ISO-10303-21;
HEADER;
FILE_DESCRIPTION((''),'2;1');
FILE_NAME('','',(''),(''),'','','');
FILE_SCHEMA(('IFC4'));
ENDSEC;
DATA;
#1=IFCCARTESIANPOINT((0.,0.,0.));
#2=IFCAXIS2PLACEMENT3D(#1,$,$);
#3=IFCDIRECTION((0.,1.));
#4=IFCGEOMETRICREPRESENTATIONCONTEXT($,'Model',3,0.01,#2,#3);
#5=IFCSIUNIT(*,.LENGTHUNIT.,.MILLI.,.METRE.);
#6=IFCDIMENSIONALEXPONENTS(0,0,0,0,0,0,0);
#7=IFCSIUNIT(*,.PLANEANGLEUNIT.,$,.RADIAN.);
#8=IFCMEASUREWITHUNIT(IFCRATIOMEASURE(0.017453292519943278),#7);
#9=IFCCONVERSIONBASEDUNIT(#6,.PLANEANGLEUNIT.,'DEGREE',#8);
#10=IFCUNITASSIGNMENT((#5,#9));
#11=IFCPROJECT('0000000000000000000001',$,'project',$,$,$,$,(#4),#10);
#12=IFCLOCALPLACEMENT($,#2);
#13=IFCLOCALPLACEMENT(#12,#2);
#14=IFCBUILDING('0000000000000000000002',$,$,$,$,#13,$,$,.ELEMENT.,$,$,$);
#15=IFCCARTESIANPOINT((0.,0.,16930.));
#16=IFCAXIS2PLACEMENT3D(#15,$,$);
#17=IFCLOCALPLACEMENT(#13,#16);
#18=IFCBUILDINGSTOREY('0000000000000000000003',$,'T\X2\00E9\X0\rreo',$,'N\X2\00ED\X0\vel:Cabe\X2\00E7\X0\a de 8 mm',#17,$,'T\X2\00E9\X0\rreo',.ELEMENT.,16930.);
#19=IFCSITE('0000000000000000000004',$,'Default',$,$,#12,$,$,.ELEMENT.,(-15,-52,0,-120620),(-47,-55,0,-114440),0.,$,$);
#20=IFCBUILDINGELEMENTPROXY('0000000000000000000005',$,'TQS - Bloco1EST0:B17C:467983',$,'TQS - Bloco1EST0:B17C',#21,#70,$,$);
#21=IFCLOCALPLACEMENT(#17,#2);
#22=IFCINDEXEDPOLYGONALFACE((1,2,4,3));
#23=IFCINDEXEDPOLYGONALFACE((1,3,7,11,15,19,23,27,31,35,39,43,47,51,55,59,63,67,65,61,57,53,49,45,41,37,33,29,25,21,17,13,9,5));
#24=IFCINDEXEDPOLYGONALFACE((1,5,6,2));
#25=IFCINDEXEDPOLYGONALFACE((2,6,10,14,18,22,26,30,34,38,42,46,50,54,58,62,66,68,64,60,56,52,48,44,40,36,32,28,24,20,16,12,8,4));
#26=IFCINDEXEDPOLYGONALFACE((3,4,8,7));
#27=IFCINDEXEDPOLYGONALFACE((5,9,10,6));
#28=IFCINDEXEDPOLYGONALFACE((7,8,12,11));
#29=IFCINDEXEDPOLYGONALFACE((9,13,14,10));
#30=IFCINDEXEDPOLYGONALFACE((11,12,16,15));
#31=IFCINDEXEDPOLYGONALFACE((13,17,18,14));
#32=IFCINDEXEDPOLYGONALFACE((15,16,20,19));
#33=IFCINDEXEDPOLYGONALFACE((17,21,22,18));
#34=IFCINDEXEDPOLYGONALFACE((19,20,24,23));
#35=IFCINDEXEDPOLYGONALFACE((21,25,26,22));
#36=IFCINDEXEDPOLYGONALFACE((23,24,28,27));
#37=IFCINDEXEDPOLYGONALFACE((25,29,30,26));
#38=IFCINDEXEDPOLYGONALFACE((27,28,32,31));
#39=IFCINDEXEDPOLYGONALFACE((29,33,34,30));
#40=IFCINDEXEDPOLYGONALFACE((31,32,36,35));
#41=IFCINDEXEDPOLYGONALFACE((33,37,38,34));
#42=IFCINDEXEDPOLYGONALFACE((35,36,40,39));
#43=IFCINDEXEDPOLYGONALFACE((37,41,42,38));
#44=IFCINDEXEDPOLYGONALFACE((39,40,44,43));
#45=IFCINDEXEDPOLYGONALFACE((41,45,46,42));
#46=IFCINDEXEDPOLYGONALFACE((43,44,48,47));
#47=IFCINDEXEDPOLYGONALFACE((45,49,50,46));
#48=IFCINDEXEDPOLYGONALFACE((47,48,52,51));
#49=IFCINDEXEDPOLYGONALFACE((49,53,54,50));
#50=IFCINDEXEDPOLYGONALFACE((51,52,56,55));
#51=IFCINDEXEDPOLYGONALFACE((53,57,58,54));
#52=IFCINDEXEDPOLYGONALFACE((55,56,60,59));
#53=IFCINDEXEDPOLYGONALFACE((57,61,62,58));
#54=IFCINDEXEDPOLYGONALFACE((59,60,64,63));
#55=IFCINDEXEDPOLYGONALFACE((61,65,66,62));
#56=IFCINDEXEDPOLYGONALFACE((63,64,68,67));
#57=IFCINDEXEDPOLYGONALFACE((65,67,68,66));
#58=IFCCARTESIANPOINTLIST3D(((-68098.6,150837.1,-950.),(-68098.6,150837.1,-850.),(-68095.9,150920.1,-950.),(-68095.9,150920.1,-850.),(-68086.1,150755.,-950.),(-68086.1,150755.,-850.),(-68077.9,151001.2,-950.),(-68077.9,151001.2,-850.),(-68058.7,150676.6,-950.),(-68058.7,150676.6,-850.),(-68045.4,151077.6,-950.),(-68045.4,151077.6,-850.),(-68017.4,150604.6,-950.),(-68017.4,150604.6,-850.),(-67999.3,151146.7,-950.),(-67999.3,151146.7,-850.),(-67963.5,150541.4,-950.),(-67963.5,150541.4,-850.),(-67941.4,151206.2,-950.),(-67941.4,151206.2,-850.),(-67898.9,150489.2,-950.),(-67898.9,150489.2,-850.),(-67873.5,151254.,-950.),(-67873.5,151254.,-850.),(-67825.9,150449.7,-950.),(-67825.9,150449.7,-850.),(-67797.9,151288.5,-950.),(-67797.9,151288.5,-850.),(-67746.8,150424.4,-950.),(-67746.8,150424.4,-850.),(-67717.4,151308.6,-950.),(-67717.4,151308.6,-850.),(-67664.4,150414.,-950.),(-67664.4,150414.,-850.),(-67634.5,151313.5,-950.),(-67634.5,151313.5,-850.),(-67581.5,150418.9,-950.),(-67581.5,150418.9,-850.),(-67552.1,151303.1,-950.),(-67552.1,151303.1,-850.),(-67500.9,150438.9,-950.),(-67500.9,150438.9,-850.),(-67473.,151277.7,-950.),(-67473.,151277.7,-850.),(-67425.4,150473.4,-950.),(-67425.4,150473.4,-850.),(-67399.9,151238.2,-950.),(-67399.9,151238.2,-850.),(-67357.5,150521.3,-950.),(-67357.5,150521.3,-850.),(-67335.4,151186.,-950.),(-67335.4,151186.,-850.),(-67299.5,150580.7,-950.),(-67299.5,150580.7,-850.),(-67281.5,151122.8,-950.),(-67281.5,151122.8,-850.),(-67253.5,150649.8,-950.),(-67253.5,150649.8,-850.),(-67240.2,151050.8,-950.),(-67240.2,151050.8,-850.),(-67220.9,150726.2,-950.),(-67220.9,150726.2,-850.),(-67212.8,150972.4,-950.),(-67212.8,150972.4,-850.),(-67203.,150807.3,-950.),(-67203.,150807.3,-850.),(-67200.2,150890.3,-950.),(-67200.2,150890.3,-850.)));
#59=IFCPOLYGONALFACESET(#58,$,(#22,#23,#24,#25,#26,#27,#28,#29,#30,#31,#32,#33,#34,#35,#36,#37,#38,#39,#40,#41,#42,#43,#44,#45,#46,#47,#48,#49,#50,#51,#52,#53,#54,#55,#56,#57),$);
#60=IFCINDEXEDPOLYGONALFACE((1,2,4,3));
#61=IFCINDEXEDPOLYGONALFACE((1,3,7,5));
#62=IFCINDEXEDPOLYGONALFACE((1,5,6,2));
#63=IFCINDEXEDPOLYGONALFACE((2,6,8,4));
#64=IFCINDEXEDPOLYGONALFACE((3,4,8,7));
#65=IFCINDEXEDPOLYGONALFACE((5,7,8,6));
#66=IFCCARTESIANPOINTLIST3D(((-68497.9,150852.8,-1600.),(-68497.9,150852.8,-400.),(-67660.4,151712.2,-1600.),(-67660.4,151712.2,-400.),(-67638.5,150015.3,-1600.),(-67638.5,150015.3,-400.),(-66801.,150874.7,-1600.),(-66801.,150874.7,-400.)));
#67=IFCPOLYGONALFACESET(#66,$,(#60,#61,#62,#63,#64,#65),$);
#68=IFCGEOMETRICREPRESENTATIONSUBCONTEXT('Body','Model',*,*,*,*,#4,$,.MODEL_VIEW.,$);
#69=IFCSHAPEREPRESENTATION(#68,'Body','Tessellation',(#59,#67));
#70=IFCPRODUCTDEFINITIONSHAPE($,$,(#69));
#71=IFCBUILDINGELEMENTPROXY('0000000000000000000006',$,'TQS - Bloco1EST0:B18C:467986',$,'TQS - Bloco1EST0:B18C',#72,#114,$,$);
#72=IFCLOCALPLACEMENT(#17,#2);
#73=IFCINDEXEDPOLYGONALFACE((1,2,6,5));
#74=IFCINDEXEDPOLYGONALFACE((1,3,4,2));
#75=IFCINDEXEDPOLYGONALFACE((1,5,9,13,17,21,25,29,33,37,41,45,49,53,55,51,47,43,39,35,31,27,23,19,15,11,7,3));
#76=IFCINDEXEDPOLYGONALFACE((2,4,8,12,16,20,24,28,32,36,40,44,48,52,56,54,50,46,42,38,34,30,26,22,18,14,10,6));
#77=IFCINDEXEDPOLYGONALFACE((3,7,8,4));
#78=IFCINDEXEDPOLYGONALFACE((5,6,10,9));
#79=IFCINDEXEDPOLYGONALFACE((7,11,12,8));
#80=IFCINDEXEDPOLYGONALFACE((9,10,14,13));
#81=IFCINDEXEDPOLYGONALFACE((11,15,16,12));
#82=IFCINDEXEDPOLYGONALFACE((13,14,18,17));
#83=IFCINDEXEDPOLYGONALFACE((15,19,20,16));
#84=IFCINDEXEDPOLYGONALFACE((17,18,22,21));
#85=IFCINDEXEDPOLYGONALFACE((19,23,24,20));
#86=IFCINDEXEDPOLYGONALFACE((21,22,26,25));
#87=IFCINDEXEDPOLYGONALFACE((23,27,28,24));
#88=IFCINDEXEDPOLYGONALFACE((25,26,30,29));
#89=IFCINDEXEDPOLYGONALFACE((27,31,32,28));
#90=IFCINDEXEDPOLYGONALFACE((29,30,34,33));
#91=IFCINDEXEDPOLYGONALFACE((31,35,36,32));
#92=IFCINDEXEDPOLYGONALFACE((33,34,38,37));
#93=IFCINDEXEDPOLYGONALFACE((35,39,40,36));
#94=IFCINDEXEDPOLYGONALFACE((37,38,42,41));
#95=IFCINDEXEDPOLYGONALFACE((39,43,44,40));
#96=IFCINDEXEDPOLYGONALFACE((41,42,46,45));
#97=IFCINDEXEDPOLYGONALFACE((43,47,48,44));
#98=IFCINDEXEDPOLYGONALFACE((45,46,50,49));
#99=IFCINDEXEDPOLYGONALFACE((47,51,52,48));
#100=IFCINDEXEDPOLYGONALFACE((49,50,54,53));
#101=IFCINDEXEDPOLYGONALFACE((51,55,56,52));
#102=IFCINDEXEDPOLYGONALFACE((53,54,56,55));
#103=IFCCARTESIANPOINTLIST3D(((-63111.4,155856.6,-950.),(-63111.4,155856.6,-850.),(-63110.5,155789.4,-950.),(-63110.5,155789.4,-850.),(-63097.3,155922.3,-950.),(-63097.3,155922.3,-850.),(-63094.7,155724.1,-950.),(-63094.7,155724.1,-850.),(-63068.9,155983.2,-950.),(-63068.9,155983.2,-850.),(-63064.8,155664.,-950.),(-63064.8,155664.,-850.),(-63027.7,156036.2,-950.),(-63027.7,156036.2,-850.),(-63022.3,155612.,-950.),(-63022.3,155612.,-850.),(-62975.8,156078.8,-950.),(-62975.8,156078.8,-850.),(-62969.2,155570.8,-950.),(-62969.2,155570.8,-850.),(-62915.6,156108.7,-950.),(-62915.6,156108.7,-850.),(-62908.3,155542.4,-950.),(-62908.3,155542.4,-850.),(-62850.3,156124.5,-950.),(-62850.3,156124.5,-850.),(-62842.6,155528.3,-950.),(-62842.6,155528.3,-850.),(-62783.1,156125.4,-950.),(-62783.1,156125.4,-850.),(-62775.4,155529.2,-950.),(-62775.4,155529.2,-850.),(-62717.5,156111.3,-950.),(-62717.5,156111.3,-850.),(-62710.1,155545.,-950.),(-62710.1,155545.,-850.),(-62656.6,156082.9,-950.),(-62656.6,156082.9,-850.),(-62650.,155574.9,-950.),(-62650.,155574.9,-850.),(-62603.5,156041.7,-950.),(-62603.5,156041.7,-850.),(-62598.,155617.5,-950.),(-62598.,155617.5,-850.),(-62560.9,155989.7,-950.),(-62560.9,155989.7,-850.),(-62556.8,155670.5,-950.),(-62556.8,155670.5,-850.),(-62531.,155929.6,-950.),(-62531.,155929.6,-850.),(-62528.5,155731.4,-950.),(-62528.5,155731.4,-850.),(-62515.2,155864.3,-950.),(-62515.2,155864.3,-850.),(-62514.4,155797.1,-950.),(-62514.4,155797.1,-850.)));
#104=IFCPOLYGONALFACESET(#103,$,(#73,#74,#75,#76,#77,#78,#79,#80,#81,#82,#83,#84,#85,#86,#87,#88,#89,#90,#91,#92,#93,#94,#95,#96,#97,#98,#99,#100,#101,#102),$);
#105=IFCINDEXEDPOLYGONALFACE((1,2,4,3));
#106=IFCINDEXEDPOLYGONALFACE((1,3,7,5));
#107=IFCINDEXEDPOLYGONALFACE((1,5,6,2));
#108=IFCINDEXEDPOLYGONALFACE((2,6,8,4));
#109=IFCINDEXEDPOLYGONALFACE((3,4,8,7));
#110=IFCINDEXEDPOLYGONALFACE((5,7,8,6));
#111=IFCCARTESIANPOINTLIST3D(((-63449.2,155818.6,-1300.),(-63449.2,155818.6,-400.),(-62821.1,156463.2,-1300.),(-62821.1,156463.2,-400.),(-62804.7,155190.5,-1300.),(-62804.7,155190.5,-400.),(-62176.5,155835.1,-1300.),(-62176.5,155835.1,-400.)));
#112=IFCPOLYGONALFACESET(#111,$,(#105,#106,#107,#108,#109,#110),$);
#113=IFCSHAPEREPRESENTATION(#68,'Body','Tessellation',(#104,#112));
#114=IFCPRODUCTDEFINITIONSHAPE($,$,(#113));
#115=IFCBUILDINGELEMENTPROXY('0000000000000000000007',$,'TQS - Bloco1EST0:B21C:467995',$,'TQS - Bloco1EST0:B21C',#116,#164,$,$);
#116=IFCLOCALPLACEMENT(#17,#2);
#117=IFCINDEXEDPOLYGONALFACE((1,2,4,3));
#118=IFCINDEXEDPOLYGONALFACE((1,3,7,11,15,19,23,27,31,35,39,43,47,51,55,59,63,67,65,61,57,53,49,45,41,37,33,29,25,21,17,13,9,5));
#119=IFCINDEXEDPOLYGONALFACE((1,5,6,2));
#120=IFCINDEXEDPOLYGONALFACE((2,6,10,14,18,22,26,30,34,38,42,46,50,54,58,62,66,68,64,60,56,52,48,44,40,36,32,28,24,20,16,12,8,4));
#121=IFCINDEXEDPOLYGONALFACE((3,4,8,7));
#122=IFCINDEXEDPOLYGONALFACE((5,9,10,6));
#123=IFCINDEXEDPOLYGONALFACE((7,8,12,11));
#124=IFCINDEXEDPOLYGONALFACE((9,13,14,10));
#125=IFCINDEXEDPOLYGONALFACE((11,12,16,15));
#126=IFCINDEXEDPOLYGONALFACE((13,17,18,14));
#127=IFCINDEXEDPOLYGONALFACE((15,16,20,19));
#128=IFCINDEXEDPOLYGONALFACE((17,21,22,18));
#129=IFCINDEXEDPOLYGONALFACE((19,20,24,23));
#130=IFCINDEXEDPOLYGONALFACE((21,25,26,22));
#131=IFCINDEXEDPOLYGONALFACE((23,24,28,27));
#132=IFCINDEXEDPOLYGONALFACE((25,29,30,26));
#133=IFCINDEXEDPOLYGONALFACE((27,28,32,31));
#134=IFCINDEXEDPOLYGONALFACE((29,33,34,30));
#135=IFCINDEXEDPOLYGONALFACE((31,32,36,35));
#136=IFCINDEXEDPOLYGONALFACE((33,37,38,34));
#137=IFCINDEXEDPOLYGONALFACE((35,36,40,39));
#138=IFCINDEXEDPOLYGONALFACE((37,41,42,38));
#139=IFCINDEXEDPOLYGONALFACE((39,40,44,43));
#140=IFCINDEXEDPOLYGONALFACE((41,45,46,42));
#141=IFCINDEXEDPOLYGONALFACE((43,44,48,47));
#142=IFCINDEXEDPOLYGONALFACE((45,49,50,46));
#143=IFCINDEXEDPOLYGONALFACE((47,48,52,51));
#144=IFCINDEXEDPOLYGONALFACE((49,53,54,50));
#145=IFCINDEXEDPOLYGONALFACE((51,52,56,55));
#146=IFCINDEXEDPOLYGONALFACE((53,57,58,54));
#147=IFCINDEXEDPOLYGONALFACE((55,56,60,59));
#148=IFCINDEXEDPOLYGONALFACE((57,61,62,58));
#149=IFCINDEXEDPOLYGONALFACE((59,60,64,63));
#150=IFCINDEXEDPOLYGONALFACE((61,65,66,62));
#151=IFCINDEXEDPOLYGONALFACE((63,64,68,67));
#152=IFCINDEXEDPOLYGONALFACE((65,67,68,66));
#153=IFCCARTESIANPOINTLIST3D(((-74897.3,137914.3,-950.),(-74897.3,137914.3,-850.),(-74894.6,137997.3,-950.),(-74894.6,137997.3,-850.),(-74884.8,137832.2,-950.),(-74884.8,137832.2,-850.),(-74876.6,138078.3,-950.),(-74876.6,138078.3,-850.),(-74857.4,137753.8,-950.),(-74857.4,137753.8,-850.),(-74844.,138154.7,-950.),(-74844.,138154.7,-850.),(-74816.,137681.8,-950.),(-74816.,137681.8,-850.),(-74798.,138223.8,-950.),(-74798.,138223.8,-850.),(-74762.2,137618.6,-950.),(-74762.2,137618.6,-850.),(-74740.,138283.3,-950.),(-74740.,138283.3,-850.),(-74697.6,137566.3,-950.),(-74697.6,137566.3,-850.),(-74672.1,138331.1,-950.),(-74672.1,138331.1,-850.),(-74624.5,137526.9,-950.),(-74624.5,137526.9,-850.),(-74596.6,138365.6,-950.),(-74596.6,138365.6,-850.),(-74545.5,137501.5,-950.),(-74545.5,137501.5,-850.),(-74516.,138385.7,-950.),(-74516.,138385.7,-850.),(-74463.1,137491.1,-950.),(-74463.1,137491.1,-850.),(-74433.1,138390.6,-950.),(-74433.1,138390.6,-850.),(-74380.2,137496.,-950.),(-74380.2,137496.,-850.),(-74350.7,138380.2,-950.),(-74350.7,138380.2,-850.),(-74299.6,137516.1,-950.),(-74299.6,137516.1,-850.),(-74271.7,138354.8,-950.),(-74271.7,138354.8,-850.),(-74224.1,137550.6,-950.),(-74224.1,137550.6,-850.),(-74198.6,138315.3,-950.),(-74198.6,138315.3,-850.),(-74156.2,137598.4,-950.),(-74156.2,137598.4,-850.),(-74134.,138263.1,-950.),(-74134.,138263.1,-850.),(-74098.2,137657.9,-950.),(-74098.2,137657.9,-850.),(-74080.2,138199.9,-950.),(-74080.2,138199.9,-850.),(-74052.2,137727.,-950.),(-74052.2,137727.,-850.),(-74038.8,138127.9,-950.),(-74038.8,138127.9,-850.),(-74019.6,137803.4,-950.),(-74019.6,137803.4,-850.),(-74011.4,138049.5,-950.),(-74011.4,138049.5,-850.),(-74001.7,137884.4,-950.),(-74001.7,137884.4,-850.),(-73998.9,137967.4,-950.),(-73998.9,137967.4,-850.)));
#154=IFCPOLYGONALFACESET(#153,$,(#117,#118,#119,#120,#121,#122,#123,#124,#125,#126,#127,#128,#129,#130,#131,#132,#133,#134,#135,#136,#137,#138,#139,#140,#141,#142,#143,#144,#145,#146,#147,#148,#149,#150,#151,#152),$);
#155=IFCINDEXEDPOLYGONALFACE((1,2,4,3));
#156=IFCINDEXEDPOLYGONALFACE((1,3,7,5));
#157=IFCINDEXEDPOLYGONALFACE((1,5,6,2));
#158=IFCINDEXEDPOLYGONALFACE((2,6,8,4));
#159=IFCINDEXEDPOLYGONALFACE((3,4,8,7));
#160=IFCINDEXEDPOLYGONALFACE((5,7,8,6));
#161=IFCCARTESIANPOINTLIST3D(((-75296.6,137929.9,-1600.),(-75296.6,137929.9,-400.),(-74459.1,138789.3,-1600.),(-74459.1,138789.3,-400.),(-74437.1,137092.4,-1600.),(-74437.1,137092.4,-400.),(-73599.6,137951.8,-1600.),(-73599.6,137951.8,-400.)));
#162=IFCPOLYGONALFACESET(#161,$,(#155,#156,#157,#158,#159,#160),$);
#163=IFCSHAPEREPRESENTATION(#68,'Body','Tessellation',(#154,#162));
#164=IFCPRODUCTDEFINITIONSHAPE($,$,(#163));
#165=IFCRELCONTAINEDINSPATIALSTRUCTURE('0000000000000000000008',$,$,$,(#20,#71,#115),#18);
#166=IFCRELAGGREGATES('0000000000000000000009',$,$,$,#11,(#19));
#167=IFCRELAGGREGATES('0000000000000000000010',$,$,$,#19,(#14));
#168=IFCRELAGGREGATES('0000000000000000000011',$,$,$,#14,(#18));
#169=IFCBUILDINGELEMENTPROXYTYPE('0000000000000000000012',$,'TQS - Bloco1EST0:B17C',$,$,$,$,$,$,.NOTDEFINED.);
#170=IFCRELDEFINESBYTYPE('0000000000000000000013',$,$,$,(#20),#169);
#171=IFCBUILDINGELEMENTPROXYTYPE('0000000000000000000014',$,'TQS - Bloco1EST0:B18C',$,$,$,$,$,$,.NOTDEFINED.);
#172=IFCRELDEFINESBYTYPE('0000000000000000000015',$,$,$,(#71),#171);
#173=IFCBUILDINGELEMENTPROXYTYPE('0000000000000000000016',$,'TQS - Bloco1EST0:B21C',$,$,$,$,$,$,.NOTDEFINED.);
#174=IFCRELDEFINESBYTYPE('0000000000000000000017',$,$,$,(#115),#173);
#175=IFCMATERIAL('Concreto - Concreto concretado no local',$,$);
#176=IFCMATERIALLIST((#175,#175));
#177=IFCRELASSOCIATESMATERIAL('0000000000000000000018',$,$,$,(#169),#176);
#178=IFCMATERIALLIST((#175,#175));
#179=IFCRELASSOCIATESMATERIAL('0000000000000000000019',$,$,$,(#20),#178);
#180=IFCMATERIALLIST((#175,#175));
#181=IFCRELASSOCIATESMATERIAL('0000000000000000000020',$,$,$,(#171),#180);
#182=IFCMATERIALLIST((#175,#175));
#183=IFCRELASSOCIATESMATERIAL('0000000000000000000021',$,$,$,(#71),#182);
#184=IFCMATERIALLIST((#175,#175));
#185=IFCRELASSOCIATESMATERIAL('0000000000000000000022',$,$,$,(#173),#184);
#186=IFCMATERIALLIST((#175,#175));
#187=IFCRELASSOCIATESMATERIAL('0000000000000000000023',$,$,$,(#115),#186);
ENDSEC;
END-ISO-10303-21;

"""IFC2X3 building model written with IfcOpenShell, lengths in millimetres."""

from ifc_helpers import new_model, entity, si_unit, converted_unit, direction, frame, frame_2d, origin, origin_2d_with_axis, place, context, subcontext, project, spatial, rectangle, circle, extrude, source, transform, mapped, material, material_list, type_object, type_shapes, element, save


model = new_model("IFC2X3")

# Units and contexts
model_context = context("Model", 3, precision=0.01, world=origin(), true_north=direction((0.0, 1.0)))
body_context = subcontext(model_context, "Body", "Model", "MODEL_VIEW")
ifc_project = project(units=[si_unit("LENGTHUNIT", "METRE", prefix="MILLI"), converted_unit("PLANEANGLEUNIT", "DEGREE", entity("IfcRatioMeasure", 0.017453292519943278), si_unit("PLANEANGLEUNIT", "RADIAN"), dimensions=[0, 0, 0, 0, 0, 0, 0])], contexts=[model_context])

# Site, building, storey
site_placement = place(None, origin())
site = spatial("IfcSite", under=ifc_project, at=site_placement, Name="Default", CompositionType="ELEMENT", RefLatitude=(-15, -52, 0, -120620), RefLongitude=(-47, -55, 0, -114440), RefElevation=0.0)
building_placement = place(site_placement, origin())
building = spatial("IfcBuilding", under=site, at=building_placement, CompositionType="ELEMENT")
storey_placement = place(building_placement, frame((0.0, 0.0, 16930.0)))
storey = spatial("IfcBuildingStorey", under=building, at=storey_placement, Name="Térreo", ObjectType="Nível:Cabeça de 8 mm", LongName="Térreo", CompositionType="ELEMENT", Elevation=16930.0)

# Building element proxies
ifc_material_1 = material(Name="Concreto - Concreto concretado no local")
ifc_material_list_1 = material_list([ifc_material_1, ifc_material_1])
ifc_material_list_2 = material_list([ifc_material_1, ifc_material_1])
building_element_proxy_type_1 = type_object("IfcBuildingElementProxyType", Name="TQS - Bloco1EST0:B17C", PredefinedType="NOTDEFINED", material=ifc_material_list_2)
shared_shape_1 = source(origin(), body_context, "Body", "SweptSolid", [
    extrude(circle(Radius=450.0, at=frame_2d((0.0, 0.0), x_axis=(1.0, 0.0))), frame((0.0, 0.0, -550.0)), (0.0, 0.0, 1.0), 100.0),
    extrude(rectangle(XDim=1200.0, YDim=1200.0, at=origin_2d_with_axis()), frame((0.0, 0.0, -1200.0), z_axis=(0.0, 0.0, 1.0), x_axis=(-1.0, 0.0, 0.0)), (0.0, 0.0, 1.0), 1200.0),
])
type_shapes(building_element_proxy_type_1, [shared_shape_1])
proxy_1_placement = place(storey_placement, frame((-67649.4, 150863.7, -400.0), z_axis=(0.0, 0.0, 1.0), x_axis=(0.697915, 0.71618, 0.0)))
element("IfcBuildingElementProxy", 1, at=proxy_1_placement, inside=storey, type_object=building_element_proxy_type_1, material=ifc_material_list_1, Name="TQS - Bloco1EST0:B17C:467983", ObjectType="TQS - Bloco1EST0:B17C", context=body_context, shape_type="MappedRepresentation", body=[
    mapped(shared_shape_1, transform((0.0, 0.0, 0.0), scale=1.0)),
])
ifc_material_list_3 = material_list([ifc_material_1, ifc_material_1])
ifc_material_list_4 = material_list([ifc_material_1, ifc_material_1])
building_element_proxy_type_2 = type_object("IfcBuildingElementProxyType", Name="TQS - Bloco1EST0:B18C", PredefinedType="NOTDEFINED", material=ifc_material_list_4)
shared_shape_2 = source(origin(), body_context, "Body", "SweptSolid", [
    extrude(circle(Radius=300.0, at=frame_2d((0.0, 0.0), x_axis=(1.0, 0.0))), frame((0.0, 0.0, -550.0)), (0.0, 0.0, 1.0), 100.0),
    extrude(rectangle(XDim=900.0, YDim=900.0, at=origin_2d_with_axis()), frame((0.0, 0.0, -900.0), z_axis=(0.0, 0.0, 1.0), x_axis=(-1.0, 0.0, 0.0)), (0.0, 0.0, 1.0), 900.0),
])
type_shapes(building_element_proxy_type_2, [shared_shape_2])
proxy_2_placement = place(storey_placement, frame((-62812.9, 155826.8, -400.0), z_axis=(0.0, 0.0, 1.0), x_axis=(0.697915, 0.71618, 0.0)))
element("IfcBuildingElementProxy", 2, at=proxy_2_placement, inside=storey, type_object=building_element_proxy_type_2, material=ifc_material_list_3, Name="TQS - Bloco1EST0:B18C:467986", ObjectType="TQS - Bloco1EST0:B18C", context=body_context, shape_type="MappedRepresentation", body=[
    mapped(shared_shape_2, transform((0.0, 0.0, 0.0), scale=1.0)),
])
ifc_material_list_5 = material_list([ifc_material_1, ifc_material_1])
ifc_material_list_6 = material_list([ifc_material_1, ifc_material_1])
building_element_proxy_type_3 = type_object("IfcBuildingElementProxyType", Name="TQS - Bloco1EST0:B21C", PredefinedType="NOTDEFINED", material=ifc_material_list_6)
shared_shape_3 = source(origin(), body_context, "Body", "SweptSolid", [
    extrude(circle(Radius=450.0, at=frame_2d((0.0, 0.0), x_axis=(1.0, 0.0))), frame((0.0, 0.0, -550.0)), (0.0, 0.0, 1.0), 100.0),
    extrude(rectangle(XDim=1200.0, YDim=1200.0, at=origin_2d_with_axis()), frame((0.0, 0.0, -1200.0), z_axis=(0.0, 0.0, 1.0), x_axis=(-1.0, 0.0, 0.0)), (0.0, 0.0, 1.0), 1200.0),
])
type_shapes(building_element_proxy_type_3, [shared_shape_3])
proxy_3_placement = place(storey_placement, frame((-74448.1, 137940.8, -400.0), z_axis=(0.0, 0.0, 1.0), x_axis=(0.697915, 0.71618, 0.0)))
element("IfcBuildingElementProxy", 3, at=proxy_3_placement, inside=storey, type_object=building_element_proxy_type_3, material=ifc_material_list_5, Name="TQS - Bloco1EST0:B21C:467995", ObjectType="TQS - Bloco1EST0:B21C", context=body_context, shape_type="MappedRepresentation", body=[
    mapped(shared_shape_3, transform((0.0, 0.0, 0.0), scale=1.0)),
])

save(model, "model.ifc")
